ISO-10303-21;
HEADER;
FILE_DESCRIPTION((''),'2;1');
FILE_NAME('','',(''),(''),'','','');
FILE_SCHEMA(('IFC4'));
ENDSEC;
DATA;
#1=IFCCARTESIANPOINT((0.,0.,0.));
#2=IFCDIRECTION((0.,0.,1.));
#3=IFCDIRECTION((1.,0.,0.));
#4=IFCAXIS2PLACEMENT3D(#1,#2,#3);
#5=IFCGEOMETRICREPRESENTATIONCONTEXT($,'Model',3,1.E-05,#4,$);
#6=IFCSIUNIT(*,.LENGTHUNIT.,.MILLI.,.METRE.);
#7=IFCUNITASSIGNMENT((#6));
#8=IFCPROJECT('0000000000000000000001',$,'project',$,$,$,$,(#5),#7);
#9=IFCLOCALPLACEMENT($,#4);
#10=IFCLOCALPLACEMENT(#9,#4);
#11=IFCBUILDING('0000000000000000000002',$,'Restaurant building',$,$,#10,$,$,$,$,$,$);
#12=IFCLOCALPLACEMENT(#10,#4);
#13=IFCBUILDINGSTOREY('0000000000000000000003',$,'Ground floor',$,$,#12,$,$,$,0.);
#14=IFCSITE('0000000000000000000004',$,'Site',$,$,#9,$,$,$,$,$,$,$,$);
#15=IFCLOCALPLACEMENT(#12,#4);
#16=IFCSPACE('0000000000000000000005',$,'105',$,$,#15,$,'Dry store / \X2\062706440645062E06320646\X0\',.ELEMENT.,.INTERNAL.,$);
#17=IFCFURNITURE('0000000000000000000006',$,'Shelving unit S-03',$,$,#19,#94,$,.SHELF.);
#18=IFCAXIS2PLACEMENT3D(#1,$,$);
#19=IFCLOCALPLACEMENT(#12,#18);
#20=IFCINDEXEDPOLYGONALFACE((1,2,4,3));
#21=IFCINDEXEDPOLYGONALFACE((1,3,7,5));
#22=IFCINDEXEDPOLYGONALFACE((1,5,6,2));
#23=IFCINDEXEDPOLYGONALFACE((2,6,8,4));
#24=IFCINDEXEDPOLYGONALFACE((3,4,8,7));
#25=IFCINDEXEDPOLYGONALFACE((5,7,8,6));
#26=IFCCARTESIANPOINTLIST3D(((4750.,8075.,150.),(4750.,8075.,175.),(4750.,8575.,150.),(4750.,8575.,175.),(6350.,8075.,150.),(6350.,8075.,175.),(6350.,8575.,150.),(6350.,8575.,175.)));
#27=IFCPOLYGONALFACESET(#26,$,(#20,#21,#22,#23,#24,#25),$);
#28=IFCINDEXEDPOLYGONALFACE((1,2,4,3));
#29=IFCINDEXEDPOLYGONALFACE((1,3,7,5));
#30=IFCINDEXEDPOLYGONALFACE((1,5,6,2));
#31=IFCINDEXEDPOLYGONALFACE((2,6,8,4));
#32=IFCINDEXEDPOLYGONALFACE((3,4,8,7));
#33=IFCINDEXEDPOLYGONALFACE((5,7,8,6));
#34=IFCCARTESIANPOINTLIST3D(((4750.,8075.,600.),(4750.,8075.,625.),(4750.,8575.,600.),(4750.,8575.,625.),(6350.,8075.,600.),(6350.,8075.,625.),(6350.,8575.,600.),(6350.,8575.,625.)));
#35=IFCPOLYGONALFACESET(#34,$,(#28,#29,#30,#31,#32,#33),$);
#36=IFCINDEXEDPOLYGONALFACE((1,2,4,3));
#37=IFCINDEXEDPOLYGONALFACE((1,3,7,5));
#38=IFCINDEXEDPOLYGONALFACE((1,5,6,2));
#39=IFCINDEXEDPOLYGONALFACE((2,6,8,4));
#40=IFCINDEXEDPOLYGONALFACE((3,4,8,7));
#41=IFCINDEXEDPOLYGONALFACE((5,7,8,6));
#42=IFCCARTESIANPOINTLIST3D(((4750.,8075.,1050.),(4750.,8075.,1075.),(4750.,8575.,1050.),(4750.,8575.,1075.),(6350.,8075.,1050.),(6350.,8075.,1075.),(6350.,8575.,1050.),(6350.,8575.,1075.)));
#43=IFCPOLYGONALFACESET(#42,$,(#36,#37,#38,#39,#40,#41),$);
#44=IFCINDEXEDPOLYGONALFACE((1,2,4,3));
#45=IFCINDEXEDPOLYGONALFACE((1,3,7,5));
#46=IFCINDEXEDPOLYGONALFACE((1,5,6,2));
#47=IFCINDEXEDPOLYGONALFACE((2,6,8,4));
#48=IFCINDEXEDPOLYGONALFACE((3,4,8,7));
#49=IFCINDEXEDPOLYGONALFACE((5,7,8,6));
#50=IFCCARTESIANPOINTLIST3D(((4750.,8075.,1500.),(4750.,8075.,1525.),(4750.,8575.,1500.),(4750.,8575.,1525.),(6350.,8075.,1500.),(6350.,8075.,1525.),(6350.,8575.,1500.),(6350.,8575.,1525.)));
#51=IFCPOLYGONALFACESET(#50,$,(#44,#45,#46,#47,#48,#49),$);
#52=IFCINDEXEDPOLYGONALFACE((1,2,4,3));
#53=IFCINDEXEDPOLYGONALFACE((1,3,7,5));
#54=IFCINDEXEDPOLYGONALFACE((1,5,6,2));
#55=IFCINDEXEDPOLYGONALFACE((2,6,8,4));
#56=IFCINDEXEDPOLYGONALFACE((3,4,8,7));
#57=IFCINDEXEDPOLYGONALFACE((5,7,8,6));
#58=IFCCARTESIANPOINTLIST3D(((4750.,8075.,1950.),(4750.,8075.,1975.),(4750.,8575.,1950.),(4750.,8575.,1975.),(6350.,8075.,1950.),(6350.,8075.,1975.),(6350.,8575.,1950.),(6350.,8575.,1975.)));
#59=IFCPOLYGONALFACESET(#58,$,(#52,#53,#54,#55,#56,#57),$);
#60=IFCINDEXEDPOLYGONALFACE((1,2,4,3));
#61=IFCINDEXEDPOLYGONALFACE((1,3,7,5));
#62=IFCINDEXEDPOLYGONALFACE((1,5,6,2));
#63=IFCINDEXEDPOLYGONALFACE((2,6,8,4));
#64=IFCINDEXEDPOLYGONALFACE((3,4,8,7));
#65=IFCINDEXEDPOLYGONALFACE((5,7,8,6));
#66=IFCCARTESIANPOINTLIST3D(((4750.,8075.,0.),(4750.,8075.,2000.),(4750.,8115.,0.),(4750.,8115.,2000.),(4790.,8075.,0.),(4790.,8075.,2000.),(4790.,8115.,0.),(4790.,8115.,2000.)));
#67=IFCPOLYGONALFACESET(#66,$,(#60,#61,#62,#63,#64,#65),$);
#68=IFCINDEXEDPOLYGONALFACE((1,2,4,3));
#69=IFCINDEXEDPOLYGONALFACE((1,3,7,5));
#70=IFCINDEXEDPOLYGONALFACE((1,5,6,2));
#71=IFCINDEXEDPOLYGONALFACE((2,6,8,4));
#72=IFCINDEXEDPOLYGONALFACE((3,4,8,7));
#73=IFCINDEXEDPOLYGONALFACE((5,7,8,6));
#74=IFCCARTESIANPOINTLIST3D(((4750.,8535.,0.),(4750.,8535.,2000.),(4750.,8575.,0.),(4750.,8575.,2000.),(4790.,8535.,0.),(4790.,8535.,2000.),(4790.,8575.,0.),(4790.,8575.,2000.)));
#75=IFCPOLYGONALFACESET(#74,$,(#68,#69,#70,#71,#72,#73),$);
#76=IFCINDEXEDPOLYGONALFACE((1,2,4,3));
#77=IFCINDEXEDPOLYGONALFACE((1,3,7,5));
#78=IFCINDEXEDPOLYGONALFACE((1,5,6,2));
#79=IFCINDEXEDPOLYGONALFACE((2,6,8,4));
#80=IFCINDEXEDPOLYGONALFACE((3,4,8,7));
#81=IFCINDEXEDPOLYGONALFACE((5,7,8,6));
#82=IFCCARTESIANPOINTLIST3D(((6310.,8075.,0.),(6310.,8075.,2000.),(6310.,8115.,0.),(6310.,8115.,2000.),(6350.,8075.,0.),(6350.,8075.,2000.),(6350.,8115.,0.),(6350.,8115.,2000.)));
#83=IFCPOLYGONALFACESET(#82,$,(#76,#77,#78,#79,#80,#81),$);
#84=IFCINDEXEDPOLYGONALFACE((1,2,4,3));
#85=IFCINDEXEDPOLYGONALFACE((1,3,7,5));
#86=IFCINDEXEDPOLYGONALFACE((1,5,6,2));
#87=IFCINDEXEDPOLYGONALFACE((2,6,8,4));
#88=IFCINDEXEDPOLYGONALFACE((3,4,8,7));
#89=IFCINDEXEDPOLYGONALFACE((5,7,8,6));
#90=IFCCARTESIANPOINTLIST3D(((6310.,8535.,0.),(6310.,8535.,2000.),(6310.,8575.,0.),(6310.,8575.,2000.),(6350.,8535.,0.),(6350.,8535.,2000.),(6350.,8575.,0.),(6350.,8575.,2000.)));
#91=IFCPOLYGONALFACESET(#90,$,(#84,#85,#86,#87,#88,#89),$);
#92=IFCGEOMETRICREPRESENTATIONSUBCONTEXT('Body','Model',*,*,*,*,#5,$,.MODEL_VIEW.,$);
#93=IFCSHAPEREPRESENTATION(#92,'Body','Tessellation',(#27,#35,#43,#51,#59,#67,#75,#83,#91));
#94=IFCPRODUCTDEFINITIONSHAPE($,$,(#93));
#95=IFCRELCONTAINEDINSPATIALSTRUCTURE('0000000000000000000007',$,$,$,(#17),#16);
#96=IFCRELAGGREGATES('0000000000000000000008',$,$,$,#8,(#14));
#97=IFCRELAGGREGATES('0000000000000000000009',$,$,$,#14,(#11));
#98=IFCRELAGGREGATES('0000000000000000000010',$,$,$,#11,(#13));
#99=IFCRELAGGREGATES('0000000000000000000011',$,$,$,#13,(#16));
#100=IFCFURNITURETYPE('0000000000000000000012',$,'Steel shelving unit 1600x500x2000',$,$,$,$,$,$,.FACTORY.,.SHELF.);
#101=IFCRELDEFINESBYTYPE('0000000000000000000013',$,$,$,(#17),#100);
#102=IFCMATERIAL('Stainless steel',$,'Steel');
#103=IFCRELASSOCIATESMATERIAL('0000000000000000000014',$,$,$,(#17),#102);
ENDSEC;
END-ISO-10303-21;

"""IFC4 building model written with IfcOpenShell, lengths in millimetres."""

from ifc_helpers import new_model, si_unit, frame, origin, origin_with_axes, origin_2d, place, context, subcontext, project, spatial, rectangle, extrude, source, transform, mapped, material, type_object, type_shapes, element, save


model = new_model("IFC4")

# Units and contexts
model_context = context("Model", 3, precision=1e-05, world=origin_with_axes())
body_context = subcontext(model_context, "Body", "Model", "MODEL_VIEW")
ifc_project = project(units=[si_unit("LENGTHUNIT", "METRE", prefix="MILLI")], contexts=[model_context])

# Site, building, storey
site_placement = place(None, origin_with_axes())
site = spatial("IfcSite", under=ifc_project, at=site_placement, Name="Site")
building_placement = place(site_placement, origin_with_axes())
building = spatial("IfcBuilding", under=site, at=building_placement, Name="Restaurant building")
storey_placement = place(building_placement, origin_with_axes())
storey = spatial("IfcBuildingStorey", under=building, at=storey_placement, Name="Ground floor", Elevation=0.0)

# Shared definitions
space_1_placement = place(storey_placement, origin_with_axes())
space_1 = spatial("IfcSpace", under=storey, at=space_1_placement, Name="105", LongName="Dry store / المخزن", CompositionType="ELEMENT", PredefinedType="INTERNAL")

# Furniture
ifc_material_1 = material(Name="Stainless steel", Category="Steel")
furniture_type_1 = type_object("IfcFurnitureType", Name="Steel shelving unit 1600x500x2000", AssemblyPlace="FACTORY", PredefinedType="SHELF")
shared_shape_1 = source(origin(), body_context, "Body", "SweptSolid", [
    extrude(rectangle(XDim=1600.0, YDim=500.0, at=origin_2d()), frame((0.0, 0.0, 150.0)), (0.0, 0.0, 1.0), 25.0),
    extrude(rectangle(XDim=1600.0, YDim=500.0, at=origin_2d()), frame((0.0, 0.0, 600.0)), (0.0, 0.0, 1.0), 25.0),
    extrude(rectangle(XDim=1600.0, YDim=500.0, at=origin_2d()), frame((0.0, 0.0, 1050.0)), (0.0, 0.0, 1.0), 25.0),
    extrude(rectangle(XDim=1600.0, YDim=500.0, at=origin_2d()), frame((0.0, 0.0, 1500.0)), (0.0, 0.0, 1.0), 25.0),
    extrude(rectangle(XDim=1600.0, YDim=500.0, at=origin_2d()), frame((0.0, 0.0, 1950.0)), (0.0, 0.0, 1.0), 25.0),
    extrude(rectangle(XDim=40.0, YDim=40.0, at=origin_2d()), frame((-780.0, -230.0, 0.0)), (0.0, 0.0, 1.0), 2000.0),
    extrude(rectangle(XDim=40.0, YDim=40.0, at=origin_2d()), frame((-780.0, 230.0, 0.0)), (0.0, 0.0, 1.0), 2000.0),
    extrude(rectangle(XDim=40.0, YDim=40.0, at=origin_2d()), frame((780.0, -230.0, 0.0)), (0.0, 0.0, 1.0), 2000.0),
    extrude(rectangle(XDim=40.0, YDim=40.0, at=origin_2d()), frame((780.0, 230.0, 0.0)), (0.0, 0.0, 1.0), 2000.0),
])
type_shapes(furniture_type_1, [shared_shape_1])
furniture_1_placement = place(storey_placement, frame((5550.0, 8325.0, 0.0)))
element("IfcFurniture", 1, at=furniture_1_placement, inside=space_1, type_object=furniture_type_1, material=ifc_material_1, Name="Shelving unit S-03", PredefinedType="SHELF", context=body_context, shape_type="MappedRepresentation", body=[
    mapped(shared_shape_1, transform((0.0, 0.0, 0.0))),
])

save(model, "model.ifc")
